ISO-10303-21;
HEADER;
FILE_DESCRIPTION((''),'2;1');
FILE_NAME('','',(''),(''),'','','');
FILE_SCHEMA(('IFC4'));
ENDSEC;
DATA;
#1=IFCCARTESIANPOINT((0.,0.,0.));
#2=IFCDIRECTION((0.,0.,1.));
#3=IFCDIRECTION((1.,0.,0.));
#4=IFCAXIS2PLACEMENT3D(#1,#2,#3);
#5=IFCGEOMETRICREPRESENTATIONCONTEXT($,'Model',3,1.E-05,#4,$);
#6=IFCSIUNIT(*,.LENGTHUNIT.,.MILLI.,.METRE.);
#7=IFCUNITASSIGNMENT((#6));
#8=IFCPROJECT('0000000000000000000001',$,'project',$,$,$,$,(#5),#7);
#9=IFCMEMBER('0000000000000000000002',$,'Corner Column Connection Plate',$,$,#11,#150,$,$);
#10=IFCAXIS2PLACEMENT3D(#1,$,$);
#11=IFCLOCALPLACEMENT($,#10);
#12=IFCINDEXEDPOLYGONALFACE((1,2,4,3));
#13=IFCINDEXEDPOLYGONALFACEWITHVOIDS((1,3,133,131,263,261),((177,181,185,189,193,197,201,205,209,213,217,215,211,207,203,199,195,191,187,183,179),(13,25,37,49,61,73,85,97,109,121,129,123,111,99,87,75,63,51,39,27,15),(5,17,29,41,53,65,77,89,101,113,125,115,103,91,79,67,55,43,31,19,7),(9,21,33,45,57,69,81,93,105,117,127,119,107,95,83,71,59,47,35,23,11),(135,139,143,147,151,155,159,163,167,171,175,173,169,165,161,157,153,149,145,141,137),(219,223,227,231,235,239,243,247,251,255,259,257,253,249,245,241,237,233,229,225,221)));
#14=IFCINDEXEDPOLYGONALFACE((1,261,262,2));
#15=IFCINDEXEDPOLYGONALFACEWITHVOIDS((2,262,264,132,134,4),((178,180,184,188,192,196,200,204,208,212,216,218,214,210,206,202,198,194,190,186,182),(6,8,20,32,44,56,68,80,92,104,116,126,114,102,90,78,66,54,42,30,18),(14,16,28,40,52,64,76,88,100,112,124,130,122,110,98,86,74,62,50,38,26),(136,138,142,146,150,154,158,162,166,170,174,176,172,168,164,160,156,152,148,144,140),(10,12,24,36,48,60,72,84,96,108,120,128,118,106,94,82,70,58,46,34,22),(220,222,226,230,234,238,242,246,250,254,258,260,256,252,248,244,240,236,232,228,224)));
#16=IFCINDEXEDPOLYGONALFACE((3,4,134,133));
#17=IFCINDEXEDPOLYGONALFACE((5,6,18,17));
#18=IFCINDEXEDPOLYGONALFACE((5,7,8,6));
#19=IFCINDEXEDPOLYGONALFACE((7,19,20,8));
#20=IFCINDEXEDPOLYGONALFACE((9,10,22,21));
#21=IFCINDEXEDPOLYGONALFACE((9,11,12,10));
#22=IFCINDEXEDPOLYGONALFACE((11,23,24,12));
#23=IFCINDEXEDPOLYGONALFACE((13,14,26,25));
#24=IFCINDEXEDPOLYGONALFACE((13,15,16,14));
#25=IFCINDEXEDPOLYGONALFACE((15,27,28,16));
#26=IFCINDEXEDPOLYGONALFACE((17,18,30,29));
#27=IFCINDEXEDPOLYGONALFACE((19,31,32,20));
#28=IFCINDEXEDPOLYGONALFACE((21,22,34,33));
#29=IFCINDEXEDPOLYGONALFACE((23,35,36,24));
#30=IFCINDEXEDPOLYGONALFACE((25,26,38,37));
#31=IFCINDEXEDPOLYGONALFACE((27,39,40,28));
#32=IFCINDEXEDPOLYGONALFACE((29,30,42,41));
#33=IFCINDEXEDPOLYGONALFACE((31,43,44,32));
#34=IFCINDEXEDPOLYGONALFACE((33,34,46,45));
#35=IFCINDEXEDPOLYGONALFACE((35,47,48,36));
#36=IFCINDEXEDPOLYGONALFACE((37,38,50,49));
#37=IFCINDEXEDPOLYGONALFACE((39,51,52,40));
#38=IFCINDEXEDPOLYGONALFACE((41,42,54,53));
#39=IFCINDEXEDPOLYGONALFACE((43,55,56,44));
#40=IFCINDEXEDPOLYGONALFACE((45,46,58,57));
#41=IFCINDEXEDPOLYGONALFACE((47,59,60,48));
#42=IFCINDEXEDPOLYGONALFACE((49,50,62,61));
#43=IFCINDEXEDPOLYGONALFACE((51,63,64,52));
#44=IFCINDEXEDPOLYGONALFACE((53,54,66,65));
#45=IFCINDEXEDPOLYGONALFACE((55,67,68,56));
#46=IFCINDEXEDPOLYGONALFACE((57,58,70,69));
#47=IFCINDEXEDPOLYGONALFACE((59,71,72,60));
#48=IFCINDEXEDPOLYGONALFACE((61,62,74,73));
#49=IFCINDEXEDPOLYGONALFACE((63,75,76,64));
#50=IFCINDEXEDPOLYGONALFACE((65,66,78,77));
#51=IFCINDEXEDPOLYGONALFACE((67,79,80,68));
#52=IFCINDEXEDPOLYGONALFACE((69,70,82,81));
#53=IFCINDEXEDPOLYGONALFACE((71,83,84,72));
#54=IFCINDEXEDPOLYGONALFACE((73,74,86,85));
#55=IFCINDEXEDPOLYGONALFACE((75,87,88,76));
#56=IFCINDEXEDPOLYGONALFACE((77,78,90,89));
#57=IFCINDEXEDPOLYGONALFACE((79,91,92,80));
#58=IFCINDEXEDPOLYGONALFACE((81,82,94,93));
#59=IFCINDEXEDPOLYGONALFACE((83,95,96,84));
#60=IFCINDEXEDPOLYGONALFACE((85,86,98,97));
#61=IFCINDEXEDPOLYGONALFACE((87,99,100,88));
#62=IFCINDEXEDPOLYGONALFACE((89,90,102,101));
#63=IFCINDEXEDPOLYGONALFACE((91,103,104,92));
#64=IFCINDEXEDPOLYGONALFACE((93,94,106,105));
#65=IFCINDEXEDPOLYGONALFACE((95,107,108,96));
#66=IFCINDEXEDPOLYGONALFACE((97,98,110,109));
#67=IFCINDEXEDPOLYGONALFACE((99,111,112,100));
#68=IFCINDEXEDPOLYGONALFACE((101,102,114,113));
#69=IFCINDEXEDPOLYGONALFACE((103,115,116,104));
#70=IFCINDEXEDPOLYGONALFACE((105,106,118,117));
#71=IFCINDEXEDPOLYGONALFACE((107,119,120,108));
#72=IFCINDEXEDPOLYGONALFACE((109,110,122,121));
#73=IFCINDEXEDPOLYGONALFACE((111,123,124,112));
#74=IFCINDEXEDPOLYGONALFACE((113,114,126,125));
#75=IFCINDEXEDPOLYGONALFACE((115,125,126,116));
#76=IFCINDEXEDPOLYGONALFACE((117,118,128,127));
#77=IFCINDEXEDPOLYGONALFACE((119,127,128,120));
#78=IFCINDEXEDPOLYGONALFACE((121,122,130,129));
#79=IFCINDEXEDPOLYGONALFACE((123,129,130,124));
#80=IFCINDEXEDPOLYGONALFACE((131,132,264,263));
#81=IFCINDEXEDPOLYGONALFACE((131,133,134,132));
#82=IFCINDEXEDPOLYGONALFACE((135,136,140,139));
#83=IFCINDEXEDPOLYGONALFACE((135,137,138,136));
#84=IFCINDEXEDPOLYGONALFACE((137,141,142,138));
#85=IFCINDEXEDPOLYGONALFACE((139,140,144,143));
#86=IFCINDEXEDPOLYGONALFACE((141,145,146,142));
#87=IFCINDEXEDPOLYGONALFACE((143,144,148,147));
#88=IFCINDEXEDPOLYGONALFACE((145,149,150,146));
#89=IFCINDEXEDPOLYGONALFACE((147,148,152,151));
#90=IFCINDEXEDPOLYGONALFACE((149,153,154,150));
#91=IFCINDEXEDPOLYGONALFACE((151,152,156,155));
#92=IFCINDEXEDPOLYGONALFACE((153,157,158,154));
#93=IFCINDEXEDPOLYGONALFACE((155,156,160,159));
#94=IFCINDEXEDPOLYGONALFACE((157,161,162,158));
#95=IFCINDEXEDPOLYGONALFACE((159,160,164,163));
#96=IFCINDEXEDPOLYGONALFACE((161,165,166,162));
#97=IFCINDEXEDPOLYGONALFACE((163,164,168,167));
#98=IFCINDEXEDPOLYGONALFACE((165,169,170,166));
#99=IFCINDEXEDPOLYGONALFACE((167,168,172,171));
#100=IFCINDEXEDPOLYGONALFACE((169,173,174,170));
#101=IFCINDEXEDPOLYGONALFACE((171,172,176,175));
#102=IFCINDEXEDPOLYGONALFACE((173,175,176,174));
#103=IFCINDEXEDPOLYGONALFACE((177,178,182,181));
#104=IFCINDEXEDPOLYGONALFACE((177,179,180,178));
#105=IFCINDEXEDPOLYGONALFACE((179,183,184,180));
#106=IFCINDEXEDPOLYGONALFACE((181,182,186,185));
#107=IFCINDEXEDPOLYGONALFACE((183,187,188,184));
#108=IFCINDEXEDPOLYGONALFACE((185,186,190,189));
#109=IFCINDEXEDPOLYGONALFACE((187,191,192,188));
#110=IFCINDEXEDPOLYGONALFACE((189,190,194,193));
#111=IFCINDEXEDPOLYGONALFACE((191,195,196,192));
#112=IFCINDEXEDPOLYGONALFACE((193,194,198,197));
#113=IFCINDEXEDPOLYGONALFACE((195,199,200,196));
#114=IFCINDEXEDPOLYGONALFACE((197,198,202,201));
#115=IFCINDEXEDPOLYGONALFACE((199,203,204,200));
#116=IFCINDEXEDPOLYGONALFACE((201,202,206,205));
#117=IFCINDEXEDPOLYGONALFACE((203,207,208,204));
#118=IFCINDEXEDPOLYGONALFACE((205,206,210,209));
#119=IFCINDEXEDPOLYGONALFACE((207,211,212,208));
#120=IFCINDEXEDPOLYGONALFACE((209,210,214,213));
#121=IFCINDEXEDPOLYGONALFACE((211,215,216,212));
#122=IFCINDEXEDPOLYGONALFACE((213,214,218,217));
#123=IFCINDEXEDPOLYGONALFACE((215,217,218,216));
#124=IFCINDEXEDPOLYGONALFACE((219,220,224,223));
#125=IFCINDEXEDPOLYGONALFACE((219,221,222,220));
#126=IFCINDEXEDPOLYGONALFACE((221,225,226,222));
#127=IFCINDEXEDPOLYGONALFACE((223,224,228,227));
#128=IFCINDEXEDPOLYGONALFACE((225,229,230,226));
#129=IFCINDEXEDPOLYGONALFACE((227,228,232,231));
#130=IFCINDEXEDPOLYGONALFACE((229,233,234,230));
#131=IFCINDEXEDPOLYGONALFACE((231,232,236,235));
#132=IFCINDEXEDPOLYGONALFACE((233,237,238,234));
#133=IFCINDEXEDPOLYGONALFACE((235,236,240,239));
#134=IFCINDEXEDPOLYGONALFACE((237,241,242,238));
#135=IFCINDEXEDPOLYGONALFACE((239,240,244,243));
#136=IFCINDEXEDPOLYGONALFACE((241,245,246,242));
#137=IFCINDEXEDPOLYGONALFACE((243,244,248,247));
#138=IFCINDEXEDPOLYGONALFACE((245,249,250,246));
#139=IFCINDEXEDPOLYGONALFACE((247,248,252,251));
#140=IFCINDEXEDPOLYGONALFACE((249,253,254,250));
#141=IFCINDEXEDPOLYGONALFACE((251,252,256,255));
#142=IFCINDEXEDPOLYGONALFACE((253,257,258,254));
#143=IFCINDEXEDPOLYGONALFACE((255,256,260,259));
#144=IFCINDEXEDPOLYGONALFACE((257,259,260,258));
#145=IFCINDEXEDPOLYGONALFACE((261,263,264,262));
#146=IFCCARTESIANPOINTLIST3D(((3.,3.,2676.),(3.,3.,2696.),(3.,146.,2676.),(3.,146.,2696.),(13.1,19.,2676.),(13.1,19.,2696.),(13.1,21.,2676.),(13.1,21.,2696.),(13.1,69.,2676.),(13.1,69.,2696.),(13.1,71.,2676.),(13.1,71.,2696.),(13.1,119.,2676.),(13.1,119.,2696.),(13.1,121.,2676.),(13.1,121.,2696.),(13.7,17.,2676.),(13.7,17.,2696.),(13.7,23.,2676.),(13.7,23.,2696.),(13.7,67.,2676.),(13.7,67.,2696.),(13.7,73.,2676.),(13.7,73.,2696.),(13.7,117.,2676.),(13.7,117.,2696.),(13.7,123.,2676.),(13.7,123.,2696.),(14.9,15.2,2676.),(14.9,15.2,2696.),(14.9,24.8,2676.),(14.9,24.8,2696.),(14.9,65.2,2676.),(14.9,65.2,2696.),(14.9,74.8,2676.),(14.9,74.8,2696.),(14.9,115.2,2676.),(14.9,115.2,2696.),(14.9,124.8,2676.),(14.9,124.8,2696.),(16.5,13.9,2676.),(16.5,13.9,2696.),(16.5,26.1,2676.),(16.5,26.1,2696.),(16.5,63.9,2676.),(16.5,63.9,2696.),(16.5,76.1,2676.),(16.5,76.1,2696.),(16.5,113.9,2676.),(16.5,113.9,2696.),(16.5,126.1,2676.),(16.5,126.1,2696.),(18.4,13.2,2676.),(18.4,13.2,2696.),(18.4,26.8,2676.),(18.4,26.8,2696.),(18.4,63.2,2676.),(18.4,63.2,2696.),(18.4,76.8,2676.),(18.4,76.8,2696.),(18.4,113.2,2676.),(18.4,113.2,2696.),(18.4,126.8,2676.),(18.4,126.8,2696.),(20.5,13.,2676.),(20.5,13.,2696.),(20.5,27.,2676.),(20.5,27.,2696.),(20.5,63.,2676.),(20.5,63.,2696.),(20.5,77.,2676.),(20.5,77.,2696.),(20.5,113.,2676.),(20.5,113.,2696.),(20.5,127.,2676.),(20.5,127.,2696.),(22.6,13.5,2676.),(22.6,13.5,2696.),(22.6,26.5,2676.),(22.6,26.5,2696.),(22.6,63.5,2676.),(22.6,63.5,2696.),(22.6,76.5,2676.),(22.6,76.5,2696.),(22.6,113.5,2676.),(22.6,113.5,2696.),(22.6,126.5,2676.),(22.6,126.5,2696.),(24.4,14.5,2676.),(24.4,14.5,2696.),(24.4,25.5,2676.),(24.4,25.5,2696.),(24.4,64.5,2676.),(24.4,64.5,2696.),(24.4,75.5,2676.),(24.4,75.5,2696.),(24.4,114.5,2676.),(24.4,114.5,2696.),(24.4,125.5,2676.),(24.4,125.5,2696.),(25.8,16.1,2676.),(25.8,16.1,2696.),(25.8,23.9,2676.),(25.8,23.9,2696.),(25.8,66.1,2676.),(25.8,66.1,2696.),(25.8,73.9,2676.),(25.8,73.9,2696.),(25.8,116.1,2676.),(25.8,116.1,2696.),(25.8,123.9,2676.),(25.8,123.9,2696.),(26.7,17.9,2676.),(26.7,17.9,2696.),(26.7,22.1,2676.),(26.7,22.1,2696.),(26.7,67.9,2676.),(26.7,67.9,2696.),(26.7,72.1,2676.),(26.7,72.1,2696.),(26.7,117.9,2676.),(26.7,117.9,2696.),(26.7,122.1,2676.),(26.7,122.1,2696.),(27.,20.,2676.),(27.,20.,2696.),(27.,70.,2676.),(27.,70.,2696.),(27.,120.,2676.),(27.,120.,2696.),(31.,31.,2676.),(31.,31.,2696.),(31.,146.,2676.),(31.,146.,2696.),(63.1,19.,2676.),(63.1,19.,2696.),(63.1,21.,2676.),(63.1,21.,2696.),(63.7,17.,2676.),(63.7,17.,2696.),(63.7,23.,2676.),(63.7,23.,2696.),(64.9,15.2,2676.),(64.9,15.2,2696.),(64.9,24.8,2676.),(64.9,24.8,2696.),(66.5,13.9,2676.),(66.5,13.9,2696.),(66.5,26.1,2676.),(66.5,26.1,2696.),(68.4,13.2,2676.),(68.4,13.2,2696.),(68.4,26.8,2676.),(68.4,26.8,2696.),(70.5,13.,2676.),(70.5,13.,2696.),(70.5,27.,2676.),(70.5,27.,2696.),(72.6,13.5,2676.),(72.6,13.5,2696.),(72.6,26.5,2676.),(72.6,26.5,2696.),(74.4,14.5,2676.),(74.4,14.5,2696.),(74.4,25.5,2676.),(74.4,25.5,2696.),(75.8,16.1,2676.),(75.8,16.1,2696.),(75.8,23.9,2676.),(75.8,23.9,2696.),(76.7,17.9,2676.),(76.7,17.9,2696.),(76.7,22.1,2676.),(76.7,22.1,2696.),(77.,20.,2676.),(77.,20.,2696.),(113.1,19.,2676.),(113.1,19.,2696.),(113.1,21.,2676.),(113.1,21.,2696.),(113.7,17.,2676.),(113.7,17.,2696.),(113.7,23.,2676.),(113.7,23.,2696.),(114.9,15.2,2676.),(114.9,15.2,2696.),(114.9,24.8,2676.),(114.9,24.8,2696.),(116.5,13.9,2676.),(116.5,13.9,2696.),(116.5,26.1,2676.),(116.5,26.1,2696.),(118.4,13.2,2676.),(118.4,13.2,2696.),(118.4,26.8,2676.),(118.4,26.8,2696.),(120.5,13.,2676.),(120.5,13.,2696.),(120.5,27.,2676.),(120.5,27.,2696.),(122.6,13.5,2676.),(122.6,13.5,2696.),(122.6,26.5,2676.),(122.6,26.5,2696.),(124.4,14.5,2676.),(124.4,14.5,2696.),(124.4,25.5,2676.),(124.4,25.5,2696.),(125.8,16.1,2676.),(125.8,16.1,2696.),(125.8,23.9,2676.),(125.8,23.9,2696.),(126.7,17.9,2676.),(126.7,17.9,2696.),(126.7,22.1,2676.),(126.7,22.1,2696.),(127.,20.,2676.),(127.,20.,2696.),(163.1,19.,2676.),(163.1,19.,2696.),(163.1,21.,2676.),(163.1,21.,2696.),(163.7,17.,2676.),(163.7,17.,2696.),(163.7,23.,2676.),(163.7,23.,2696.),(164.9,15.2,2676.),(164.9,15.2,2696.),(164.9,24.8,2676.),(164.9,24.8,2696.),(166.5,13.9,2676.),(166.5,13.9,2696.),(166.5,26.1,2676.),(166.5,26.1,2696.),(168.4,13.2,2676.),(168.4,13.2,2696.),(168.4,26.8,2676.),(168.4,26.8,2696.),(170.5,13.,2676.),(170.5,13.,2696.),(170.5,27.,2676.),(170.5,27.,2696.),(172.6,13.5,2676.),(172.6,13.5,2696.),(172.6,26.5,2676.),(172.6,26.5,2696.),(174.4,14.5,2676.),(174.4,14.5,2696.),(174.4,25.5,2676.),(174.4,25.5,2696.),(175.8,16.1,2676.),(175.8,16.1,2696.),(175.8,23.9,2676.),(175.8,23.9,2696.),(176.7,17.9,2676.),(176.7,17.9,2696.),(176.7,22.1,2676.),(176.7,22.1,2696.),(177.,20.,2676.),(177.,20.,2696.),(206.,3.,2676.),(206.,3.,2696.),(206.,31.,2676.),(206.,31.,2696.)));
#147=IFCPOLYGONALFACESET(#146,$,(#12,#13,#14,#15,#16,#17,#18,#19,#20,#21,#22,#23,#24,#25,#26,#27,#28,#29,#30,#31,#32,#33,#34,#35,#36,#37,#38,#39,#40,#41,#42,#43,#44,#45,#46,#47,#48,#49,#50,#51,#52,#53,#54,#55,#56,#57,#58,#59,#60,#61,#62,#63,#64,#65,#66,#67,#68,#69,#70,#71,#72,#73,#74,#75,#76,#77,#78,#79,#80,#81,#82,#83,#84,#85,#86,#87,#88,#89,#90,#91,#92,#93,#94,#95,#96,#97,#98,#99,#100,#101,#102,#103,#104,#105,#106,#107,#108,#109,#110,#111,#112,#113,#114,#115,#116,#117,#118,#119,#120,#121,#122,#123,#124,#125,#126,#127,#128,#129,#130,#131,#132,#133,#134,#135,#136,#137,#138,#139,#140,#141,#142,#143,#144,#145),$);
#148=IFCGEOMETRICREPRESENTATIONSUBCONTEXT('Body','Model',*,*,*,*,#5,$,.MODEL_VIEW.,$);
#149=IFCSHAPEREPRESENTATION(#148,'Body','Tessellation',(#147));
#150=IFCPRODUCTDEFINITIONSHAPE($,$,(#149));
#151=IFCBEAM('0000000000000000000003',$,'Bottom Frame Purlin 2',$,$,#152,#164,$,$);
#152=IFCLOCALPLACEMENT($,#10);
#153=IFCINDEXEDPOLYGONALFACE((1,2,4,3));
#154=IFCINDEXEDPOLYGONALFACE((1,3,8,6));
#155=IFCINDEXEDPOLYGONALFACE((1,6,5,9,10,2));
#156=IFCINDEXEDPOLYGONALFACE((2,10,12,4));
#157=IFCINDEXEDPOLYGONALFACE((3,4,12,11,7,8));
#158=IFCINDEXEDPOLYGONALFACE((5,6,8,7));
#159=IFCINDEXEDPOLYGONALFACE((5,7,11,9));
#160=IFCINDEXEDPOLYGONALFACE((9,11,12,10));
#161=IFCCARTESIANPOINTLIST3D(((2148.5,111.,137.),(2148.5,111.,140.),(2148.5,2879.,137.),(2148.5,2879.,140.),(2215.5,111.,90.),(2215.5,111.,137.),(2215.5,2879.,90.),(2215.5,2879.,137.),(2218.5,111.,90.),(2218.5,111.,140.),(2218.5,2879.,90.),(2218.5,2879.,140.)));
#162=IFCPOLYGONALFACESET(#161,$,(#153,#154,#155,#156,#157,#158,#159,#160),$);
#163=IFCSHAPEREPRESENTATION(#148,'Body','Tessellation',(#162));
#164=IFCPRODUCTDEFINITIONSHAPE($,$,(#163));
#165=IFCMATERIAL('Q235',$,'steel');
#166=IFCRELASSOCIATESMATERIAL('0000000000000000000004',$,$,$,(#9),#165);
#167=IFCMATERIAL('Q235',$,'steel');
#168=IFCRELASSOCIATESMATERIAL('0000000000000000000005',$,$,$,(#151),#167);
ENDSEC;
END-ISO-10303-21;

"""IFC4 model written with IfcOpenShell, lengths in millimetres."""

from ifc_helpers import new_model, si_unit, frame, origin_with_axes, origin_2d, place, context, subcontext, project, line, indexed_curve, circle_curve, outline, extrude, material, element, save


model = new_model("IFC4")

# Units and contexts
model_context = context("Model", 3, precision=1e-05, world=origin_with_axes())
body_context = subcontext(model_context, "Body", "Model", "MODEL_VIEW")
ifc_project = project(units=[si_unit("LENGTHUNIT", "METRE", prefix="MILLI")], contexts=[model_context])

# Member, openings
ifc_material_1 = material(Name="Q235", Category="steel")
member_1_placement = place(None, frame((3.0, 3.0, 2676.0), z_axis=(0.0, 0.0, 1.0), x_axis=(1.0, 0.0, 0.0)))
member_1 = element("IfcMember", 1, at=member_1_placement, material=ifc_material_1, Name="Corner Column Connection Plate", context=body_context, shape_type="SweptSolid", body=[
    extrude(outline(indexed_curve([(0.0, 0.0), (203.0, 0.0), (203.0, 28.0), (28.0, 28.0), (28.0, 143.0), (0.0, 143.0), (0.0, 0.0)], segments=[line(1, 2, 3, 4, 5, 6, 7, 1)])), origin_with_axes(), (0.0, 0.0, 1.0), 20.0),
])
opening_1_placement = place(member_1_placement, frame((17.0, 17.0, 0.0), z_axis=(0.0, 0.0, 1.0), x_axis=(1.0, 0.0, 0.0)))
element("IfcOpeningElement", 2, at=opening_1_placement, cuts=member_1, context=body_context, shape_type="SweptSolid", body=[
    extrude(outline(circle_curve(origin_2d(), 7.0)), origin_with_axes(), (0.0, 0.0, 1.0), 20.0),
])
opening_2_placement = place(member_1_placement, frame((67.0, 17.0, 0.0), z_axis=(0.0, 0.0, 1.0), x_axis=(1.0, 0.0, 0.0)))
element("IfcOpeningElement", 3, at=opening_2_placement, cuts=member_1, context=body_context, shape_type="SweptSolid", body=[
    extrude(outline(circle_curve(origin_2d(), 7.0)), origin_with_axes(), (0.0, 0.0, 1.0), 20.0),
])
opening_3_placement = place(member_1_placement, frame((117.0, 17.0, 0.0), z_axis=(0.0, 0.0, 1.0), x_axis=(1.0, 0.0, 0.0)))
element("IfcOpeningElement", 4, at=opening_3_placement, cuts=member_1, context=body_context, shape_type="SweptSolid", body=[
    extrude(outline(circle_curve(origin_2d(), 7.0)), origin_with_axes(), (0.0, 0.0, 1.0), 20.0),
])
opening_4_placement = place(member_1_placement, frame((167.0, 17.0, 0.0), z_axis=(0.0, 0.0, 1.0), x_axis=(1.0, 0.0, 0.0)))
element("IfcOpeningElement", 5, at=opening_4_placement, cuts=member_1, context=body_context, shape_type="SweptSolid", body=[
    extrude(outline(circle_curve(origin_2d(), 7.0)), origin_with_axes(), (0.0, 0.0, 1.0), 20.0),
])
opening_5_placement = place(member_1_placement, frame((17.0, 67.0, 0.0), z_axis=(0.0, 0.0, 1.0), x_axis=(1.0, 0.0, 0.0)))
element("IfcOpeningElement", 6, at=opening_5_placement, cuts=member_1, context=body_context, shape_type="SweptSolid", body=[
    extrude(outline(circle_curve(origin_2d(), 7.0)), origin_with_axes(), (0.0, 0.0, 1.0), 20.0),
])
opening_6_placement = place(member_1_placement, frame((17.0, 117.0, 0.0), z_axis=(0.0, 0.0, 1.0), x_axis=(1.0, 0.0, 0.0)))
element("IfcOpeningElement", 7, at=opening_6_placement, cuts=member_1, context=body_context, shape_type="SweptSolid", body=[
    extrude(outline(circle_curve(origin_2d(), 7.0)), origin_with_axes(), (0.0, 0.0, 1.0), 20.0),
])

# Beam
ifc_material_2 = material(Name="Q235", Category="steel")
beam_1_placement = place(None, frame((2218.5, 111.0, 140.0), z_axis=(0.0, 1.0, 0.0), x_axis=(-1.0, 0.0, 0.0)))
element("IfcBeam", 8, at=beam_1_placement, material=ifc_material_2, Name="Bottom Frame Purlin 2", context=body_context, shape_type="SweptSolid", body=[
    extrude(outline(indexed_curve([(0.0, 0.0), (0.0, -50.0), (3.0, -50.0), (3.0, -3.0), (70.0, -3.0), (70.0, 0.0), (0.0, 0.0)], segments=[line(1, 2, 3, 4, 5, 6, 7, 1)])), origin_with_axes(), (0.0, 0.0, 1.0), 2768.0),
])

save(model, "model.ifc")
